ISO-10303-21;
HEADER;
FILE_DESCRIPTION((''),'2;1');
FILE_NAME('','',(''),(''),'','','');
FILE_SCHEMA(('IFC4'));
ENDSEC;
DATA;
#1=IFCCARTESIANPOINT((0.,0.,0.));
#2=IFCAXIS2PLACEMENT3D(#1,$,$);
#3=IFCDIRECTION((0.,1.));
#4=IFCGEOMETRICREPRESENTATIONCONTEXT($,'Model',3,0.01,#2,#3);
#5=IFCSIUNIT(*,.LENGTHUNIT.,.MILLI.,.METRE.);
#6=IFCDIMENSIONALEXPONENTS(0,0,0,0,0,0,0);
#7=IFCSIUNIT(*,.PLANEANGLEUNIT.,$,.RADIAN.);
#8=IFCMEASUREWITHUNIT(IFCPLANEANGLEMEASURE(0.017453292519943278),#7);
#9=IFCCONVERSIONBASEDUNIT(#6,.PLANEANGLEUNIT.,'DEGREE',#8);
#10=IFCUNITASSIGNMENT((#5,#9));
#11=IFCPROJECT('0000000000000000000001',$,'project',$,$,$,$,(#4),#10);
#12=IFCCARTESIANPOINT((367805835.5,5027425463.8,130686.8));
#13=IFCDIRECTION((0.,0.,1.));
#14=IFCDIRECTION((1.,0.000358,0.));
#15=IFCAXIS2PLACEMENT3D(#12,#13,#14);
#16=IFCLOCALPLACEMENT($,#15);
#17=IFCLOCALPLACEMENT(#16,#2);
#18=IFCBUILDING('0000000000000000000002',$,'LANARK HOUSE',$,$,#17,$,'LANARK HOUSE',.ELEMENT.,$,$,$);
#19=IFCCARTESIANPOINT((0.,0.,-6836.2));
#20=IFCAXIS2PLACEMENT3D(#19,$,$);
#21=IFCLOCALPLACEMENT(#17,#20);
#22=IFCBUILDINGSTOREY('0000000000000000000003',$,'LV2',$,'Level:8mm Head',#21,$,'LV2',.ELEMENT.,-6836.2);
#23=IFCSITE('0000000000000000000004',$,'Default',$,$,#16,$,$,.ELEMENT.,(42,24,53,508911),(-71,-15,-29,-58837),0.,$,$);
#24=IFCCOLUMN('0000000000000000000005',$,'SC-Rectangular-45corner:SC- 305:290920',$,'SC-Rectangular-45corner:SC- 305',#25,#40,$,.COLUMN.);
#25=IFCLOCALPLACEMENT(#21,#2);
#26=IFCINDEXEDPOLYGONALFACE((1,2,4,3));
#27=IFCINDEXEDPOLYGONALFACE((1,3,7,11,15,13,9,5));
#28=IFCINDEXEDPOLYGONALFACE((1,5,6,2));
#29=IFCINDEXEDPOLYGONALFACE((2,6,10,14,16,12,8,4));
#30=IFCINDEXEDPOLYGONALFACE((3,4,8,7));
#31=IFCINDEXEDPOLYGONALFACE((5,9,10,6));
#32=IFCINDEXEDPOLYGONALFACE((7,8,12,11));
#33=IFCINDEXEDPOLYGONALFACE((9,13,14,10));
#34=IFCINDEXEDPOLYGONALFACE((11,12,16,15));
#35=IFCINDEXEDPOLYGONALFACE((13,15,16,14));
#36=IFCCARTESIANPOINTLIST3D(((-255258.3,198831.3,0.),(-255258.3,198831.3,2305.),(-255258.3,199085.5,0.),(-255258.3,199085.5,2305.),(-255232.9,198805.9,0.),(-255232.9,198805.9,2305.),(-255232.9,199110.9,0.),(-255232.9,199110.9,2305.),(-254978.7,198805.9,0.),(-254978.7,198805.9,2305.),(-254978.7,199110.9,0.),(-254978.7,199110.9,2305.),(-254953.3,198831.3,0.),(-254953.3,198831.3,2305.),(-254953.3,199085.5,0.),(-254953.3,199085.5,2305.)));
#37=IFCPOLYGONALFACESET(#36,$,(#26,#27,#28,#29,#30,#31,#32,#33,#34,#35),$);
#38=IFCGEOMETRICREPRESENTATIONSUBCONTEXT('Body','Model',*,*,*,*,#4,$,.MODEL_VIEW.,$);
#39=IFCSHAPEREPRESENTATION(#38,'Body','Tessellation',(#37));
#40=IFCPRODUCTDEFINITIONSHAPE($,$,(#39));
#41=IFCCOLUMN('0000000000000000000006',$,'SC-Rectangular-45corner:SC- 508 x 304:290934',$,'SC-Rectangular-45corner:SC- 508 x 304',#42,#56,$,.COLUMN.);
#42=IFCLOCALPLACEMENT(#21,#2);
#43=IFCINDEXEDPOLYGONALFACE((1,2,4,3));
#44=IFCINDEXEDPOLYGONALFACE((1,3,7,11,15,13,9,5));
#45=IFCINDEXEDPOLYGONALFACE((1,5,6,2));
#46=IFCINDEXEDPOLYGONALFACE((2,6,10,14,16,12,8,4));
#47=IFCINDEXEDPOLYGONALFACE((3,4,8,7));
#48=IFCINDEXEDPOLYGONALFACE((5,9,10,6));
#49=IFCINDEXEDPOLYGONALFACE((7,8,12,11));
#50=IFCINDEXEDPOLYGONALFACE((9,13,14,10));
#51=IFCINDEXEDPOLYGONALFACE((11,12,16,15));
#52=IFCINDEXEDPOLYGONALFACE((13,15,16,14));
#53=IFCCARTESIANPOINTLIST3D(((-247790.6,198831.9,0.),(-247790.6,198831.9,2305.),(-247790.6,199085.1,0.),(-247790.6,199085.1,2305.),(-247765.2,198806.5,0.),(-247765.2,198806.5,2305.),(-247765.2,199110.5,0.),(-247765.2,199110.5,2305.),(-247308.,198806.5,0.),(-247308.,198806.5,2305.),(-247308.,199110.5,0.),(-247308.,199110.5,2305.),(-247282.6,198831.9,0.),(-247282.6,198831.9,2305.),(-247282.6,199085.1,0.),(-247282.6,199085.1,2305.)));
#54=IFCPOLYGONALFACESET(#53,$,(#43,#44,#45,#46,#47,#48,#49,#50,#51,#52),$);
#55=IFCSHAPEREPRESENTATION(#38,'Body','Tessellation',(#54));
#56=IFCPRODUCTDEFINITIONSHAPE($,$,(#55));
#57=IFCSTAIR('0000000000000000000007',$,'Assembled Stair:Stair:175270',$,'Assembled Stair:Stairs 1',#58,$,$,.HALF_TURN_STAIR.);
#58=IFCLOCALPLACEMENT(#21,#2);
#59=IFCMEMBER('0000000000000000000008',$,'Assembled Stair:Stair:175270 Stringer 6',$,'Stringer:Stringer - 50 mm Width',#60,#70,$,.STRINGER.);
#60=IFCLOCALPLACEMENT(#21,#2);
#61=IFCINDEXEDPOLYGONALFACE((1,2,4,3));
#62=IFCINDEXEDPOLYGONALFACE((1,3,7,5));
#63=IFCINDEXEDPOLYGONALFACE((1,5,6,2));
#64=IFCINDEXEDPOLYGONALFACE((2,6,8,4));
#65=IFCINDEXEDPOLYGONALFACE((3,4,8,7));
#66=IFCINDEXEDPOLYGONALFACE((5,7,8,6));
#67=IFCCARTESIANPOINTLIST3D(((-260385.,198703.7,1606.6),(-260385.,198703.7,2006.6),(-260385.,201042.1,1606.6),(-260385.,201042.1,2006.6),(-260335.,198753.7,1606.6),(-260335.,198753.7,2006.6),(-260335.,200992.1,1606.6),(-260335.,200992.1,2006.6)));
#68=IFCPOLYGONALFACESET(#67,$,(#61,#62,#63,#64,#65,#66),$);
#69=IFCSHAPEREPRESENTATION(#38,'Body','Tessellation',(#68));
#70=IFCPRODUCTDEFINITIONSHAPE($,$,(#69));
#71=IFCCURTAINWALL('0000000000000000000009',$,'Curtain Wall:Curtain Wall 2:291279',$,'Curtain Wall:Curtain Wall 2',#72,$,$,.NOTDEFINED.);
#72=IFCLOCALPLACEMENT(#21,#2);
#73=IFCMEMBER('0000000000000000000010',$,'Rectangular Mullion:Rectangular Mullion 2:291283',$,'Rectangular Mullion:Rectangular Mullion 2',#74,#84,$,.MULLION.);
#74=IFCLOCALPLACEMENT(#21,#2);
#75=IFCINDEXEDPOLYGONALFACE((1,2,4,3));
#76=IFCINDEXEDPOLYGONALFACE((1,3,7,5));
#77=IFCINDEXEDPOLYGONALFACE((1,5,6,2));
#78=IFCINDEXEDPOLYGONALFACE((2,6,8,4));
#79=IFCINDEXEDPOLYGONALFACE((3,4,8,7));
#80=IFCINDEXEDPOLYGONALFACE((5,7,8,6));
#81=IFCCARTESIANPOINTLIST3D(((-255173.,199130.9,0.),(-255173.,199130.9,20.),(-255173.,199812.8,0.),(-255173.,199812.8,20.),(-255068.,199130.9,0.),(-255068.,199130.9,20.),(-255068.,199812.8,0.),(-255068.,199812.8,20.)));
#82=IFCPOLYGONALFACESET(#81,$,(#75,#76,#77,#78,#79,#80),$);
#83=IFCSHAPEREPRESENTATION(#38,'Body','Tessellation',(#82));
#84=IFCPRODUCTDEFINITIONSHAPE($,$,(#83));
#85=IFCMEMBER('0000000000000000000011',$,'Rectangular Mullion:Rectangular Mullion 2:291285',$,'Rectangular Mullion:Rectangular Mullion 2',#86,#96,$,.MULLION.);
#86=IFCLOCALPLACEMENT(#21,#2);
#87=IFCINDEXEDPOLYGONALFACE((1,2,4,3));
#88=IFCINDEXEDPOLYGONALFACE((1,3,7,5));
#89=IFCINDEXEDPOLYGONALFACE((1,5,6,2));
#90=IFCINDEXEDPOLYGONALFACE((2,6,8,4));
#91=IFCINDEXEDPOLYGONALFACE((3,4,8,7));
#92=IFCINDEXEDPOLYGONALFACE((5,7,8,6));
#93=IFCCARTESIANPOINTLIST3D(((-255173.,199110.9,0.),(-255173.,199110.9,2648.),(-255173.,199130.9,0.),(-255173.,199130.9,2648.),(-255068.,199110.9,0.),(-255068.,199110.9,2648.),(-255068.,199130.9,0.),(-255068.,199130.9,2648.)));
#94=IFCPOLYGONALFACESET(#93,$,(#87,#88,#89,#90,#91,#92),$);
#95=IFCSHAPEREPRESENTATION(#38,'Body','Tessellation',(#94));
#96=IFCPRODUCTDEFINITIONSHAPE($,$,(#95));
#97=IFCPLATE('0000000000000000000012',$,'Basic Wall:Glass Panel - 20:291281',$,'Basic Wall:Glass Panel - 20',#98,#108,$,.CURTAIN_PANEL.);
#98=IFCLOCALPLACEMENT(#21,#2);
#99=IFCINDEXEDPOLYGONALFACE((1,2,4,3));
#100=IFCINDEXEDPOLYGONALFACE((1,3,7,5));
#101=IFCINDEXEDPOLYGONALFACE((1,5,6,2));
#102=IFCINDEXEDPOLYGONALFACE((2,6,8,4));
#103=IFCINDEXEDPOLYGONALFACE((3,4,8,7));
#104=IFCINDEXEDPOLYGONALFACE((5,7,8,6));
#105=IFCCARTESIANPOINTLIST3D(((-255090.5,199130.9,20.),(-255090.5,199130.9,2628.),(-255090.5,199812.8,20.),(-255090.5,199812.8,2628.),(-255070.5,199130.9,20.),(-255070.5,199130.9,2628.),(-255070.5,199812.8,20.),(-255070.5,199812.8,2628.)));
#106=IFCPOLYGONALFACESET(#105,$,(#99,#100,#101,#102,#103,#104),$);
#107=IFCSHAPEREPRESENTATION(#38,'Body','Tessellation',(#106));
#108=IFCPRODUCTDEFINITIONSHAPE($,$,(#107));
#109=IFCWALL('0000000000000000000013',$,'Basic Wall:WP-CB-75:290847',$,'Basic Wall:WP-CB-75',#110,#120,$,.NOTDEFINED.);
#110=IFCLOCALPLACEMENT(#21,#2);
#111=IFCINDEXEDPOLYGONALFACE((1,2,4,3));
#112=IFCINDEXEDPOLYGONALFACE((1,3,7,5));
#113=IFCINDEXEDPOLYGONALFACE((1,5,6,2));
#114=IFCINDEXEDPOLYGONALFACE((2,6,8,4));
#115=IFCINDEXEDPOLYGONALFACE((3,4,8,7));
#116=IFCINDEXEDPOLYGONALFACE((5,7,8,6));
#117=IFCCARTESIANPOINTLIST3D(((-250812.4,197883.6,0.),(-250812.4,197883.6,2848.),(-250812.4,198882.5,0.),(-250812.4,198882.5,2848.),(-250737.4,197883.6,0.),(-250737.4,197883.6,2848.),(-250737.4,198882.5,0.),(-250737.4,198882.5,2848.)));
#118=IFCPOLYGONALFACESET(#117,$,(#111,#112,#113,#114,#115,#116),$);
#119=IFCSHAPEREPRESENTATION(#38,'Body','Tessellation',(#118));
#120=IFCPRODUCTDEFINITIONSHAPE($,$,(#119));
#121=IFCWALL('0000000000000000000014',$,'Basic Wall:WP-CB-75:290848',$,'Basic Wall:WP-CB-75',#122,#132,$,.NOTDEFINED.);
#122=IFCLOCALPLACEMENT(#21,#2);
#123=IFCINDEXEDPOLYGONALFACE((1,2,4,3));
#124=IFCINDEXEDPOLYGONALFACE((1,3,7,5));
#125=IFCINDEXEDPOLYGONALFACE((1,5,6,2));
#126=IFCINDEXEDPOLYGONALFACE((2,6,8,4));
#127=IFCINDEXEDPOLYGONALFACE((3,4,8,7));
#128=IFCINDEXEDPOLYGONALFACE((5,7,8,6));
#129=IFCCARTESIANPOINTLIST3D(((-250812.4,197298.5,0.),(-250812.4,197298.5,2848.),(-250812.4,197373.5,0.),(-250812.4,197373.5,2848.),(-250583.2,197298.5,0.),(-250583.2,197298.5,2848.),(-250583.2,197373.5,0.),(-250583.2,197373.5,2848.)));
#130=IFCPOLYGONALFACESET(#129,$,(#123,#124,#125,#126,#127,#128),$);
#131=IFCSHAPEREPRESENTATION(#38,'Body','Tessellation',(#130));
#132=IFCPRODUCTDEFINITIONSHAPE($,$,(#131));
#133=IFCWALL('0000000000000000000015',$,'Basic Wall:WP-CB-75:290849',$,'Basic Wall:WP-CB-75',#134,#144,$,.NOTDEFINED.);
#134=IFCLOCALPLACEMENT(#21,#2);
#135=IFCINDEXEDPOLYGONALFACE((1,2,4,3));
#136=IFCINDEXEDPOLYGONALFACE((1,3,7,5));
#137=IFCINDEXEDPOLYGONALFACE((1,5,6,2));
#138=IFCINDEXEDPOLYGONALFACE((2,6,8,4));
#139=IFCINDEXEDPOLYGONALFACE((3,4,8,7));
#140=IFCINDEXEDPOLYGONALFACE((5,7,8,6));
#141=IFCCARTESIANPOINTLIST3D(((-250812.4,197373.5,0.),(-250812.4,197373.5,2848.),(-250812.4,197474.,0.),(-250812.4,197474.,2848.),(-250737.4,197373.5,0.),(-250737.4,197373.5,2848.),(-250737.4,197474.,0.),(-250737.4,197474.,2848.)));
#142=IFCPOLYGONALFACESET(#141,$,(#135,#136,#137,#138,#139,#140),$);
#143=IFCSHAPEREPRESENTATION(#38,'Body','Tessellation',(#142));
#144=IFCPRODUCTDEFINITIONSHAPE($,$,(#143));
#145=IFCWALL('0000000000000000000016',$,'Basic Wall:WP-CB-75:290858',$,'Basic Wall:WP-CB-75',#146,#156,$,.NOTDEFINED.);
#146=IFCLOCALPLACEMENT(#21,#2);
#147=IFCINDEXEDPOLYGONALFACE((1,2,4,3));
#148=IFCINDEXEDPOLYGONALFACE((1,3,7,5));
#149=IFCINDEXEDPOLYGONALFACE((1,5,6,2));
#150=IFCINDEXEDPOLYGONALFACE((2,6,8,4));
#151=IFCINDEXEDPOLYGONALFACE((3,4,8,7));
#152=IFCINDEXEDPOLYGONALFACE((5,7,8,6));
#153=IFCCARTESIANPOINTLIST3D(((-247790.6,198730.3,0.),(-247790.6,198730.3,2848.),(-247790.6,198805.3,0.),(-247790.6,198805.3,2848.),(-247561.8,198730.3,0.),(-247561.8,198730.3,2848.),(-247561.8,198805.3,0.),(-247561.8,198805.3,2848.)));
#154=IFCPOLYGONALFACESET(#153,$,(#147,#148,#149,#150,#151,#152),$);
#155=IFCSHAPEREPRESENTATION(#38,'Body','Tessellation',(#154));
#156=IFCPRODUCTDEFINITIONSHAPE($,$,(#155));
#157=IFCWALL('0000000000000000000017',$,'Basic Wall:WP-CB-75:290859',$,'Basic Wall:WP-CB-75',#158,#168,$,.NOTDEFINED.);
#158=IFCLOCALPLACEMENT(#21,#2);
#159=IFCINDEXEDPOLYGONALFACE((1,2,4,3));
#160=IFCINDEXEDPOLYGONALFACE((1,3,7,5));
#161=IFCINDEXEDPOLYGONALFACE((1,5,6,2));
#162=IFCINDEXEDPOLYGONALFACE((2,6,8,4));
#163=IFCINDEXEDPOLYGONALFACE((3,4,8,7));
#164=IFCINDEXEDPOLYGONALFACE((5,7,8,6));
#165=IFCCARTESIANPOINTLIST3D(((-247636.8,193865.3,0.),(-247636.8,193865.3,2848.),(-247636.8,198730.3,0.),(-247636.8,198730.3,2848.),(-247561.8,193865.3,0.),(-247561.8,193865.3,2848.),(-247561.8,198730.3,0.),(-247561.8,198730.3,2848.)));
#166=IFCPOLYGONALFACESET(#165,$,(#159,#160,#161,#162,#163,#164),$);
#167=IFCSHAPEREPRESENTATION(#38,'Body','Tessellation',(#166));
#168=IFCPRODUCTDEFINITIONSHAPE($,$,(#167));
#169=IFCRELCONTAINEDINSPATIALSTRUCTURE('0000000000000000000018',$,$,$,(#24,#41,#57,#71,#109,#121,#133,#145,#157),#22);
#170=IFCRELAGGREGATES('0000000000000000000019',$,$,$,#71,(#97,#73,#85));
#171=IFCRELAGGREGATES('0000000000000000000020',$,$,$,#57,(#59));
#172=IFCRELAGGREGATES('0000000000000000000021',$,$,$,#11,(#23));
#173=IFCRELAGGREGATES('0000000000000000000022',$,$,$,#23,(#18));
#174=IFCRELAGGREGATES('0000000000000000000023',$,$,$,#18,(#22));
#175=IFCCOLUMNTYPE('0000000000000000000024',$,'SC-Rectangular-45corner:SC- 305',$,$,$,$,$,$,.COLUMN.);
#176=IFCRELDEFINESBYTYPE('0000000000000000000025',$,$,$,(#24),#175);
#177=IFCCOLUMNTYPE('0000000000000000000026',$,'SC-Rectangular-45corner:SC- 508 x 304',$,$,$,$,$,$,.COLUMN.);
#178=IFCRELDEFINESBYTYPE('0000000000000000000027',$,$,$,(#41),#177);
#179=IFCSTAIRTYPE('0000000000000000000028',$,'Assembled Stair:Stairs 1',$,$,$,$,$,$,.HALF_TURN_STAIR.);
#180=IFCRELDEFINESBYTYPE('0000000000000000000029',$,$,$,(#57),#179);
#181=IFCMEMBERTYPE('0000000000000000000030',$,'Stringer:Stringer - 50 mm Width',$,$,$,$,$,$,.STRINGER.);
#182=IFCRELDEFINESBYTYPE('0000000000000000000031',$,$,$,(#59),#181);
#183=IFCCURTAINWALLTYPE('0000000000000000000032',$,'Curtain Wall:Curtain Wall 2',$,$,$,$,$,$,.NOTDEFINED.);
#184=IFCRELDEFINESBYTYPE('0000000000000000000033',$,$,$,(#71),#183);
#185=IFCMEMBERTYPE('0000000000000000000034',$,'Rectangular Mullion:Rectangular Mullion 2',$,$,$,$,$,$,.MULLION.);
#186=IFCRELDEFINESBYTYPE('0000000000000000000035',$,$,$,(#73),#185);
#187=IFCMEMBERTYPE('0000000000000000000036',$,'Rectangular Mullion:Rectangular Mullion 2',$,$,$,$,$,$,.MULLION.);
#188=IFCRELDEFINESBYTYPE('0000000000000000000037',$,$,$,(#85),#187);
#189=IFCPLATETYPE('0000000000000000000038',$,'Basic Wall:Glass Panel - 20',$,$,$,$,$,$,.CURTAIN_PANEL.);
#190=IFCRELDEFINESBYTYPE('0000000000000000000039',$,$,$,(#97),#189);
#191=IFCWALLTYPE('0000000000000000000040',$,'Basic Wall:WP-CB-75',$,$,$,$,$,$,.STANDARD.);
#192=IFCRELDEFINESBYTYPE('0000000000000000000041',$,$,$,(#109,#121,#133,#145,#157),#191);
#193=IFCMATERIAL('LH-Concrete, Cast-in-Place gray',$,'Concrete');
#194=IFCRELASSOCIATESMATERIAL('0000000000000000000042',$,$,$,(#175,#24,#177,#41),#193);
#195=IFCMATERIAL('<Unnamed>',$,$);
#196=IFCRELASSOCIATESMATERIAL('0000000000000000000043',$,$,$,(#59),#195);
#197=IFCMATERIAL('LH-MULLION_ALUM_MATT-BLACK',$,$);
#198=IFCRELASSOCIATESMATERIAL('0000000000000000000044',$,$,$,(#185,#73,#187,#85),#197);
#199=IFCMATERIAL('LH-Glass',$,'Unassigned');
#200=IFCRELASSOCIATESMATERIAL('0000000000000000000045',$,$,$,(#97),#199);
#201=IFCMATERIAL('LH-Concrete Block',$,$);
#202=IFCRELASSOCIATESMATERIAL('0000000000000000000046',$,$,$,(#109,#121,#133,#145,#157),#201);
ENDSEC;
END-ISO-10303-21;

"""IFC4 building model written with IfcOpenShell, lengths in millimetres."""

from ifc_helpers import new_model, entity, si_unit, converted_unit, direction, frame, origin, place, context, subcontext, project, spatial, indexed_curve, outline, extrude, source, transform, mapped, material, type_object, type_shapes, element, aggregate, save


model = new_model("IFC4")

# Units and contexts
model_context = context("Model", 3, precision=0.01, world=origin(), true_north=direction((0.0, 1.0)))
body_context = subcontext(model_context, "Body", "Model", "MODEL_VIEW")
ifc_project = project(units=[si_unit("LENGTHUNIT", "METRE", prefix="MILLI"), converted_unit("PLANEANGLEUNIT", "DEGREE", entity("IfcPlaneAngleMeasure", 0.017453292519943278), si_unit("PLANEANGLEUNIT", "RADIAN"), dimensions=[0, 0, 0, 0, 0, 0, 0])], contexts=[model_context])

# Site, building, storey
site_placement = place(None, frame((367805835.5, 5027425463.8, 130686.8), z_axis=(0.0, 0.0, 1.0), x_axis=(1.0, 0.000358, 0.0)))
site = spatial("IfcSite", under=ifc_project, at=site_placement, Name="Default", CompositionType="ELEMENT", RefLatitude=(42, 24, 53, 508911), RefLongitude=(-71, -15, -29, -58837), RefElevation=0.0)
building_placement = place(site_placement, origin())
building = spatial("IfcBuilding", under=site, at=building_placement, Name="LANARK HOUSE", LongName="LANARK HOUSE", CompositionType="ELEMENT")
storey_placement = place(building_placement, frame((0.0, 0.0, -6836.2)))
storey = spatial("IfcBuildingStorey", under=building, at=storey_placement, Name="LV2", ObjectType="Level:8mm Head", LongName="LV2", CompositionType="ELEMENT", Elevation=-6836.2)

# Columns
ifc_material_1 = material(Name="LH-Concrete, Cast-in-Place gray", Category="Concrete")
column_type_1 = type_object("IfcColumnType", Name="SC-Rectangular-45corner:SC- 305", PredefinedType="COLUMN", material=ifc_material_1)
shared_shape_1 = source(origin(), body_context, "Body", "SweptSolid", [
    extrude(outline(indexed_curve([(-127.1, -152.5), (127.1, -152.5), (152.5, -127.1), (152.5, 127.1), (127.1, 152.5), (-127.1, 152.5), (-152.5, 127.1), (-152.5, -127.1), (-127.1, -152.5)], self_intersect=False)), frame((0.0, 0.0, -6836.2), z_axis=(0.0, 0.0, 1.0), x_axis=(-1.0, 0.0, 0.0)), (0.0, 0.0, 1.0), 2305.0),
])
type_shapes(column_type_1, [shared_shape_1])
column_1_placement = place(storey_placement, frame((-255105.8, 198958.4, 6836.2)))
element("IfcColumn", 1, at=column_1_placement, inside=storey, type_object=column_type_1, material=ifc_material_1, Name="SC-Rectangular-45corner:SC- 305:290920", ObjectType="SC-Rectangular-45corner:SC- 305", PredefinedType="COLUMN", context=body_context, shape_type="MappedRepresentation", body=[
    mapped(shared_shape_1, transform((0.0, 0.0, 0.0), scale=1.0)),
])
column_type_2 = type_object("IfcColumnType", Name="SC-Rectangular-45corner:SC- 508 x 304", PredefinedType="COLUMN", material=ifc_material_1)
shared_shape_2 = source(origin(), body_context, "Body", "SweptSolid", [
    extrude(outline(indexed_curve([(-228.6, -152.0), (228.6, -152.0), (254.0, -126.6), (254.0, 126.6), (228.6, 152.0), (-228.6, 152.0), (-254.0, 126.6), (-254.0, -126.6), (-228.6, -152.0)], self_intersect=False)), frame((0.0, 0.0, -6836.2), z_axis=(0.0, 0.0, 1.0), x_axis=(-1.0, 0.0, 0.0)), (0.0, 0.0, 1.0), 2305.0),
])
type_shapes(column_type_2, [shared_shape_2])
column_2_placement = place(storey_placement, frame((-247536.6, 198958.5, 6836.2)))
element("IfcColumn", 2, at=column_2_placement, inside=storey, type_object=column_type_2, material=ifc_material_1, Name="SC-Rectangular-45corner:SC- 508 x 304:290934", ObjectType="SC-Rectangular-45corner:SC- 508 x 304", PredefinedType="COLUMN", context=body_context, shape_type="MappedRepresentation", body=[
    mapped(shared_shape_2, transform((0.0, 0.0, 0.0), scale=1.0)),
])

# Stair, member
stair_type = type_object("IfcStairType", Name="Assembled Stair:Stairs 1", PredefinedType="HALF_TURN_STAIR")
stair_placement = place(storey_placement, origin())
stair = element("IfcStair", 3, at=stair_placement, inside=storey, type_object=stair_type, Name="Assembled Stair:Stair:175270", ObjectType="Assembled Stair:Stairs 1", PredefinedType="HALF_TURN_STAIR")
ifc_material_2 = material(Name="<Unnamed>")
member_type_1 = type_object("IfcMemberType", Name="Stringer:Stringer - 50 mm Width", PredefinedType="STRINGER")
member_1_placement = place(stair_placement, frame((-260385.0, 198703.7, 1606.6)))
member_1 = element("IfcMember", 4, at=member_1_placement, type_object=member_type_1, material=ifc_material_2, Name="Assembled Stair:Stair:175270 Stringer 6", ObjectType="Stringer:Stringer - 50 mm Width", PredefinedType="STRINGER", context=body_context, shape_type="SweptSolid", body=[
    extrude(outline(indexed_curve([(-1169.2, -25.0), (1169.2, -25.0), (1119.2, 25.0), (-1119.2, 25.0), (-1169.2, -25.0)], self_intersect=False)), frame((25.0, 1169.2, 0.0), z_axis=(0.0, 0.0, 1.0), x_axis=(0.0, -1.0, 0.0)), (0.0, 0.0, 1.0), 400.0),
])

# Curtain wall, members
curtain_wall_type = type_object("IfcCurtainWallType", Name="Curtain Wall:Curtain Wall 2", PredefinedType="NOTDEFINED")
curtain_wall_placement = place(storey_placement, frame((0.0, 0.0, 6836.2)))
curtain_wall = element("IfcCurtainWall", 5, at=curtain_wall_placement, inside=storey, type_object=curtain_wall_type, Name="Curtain Wall:Curtain Wall 2:291279", ObjectType="Curtain Wall:Curtain Wall 2", PredefinedType="NOTDEFINED")
ifc_material_3 = material(Name="LH-MULLION_ALUM_MATT-BLACK")
member_type_2 = type_object("IfcMemberType", Name="Rectangular Mullion:Rectangular Mullion 2", PredefinedType="MULLION", material=ifc_material_3)
shared_shape_3 = source(origin(), body_context, "Body", "SweptSolid", [
    extrude(outline(indexed_curve([(-10.0, -52.5), (10.0, -52.5), (10.0, 52.5), (-10.0, 52.5), (-10.0, -52.5)], self_intersect=False)), frame((-10.0, -40.0, -681.9), z_axis=(0.0, 0.0, 1.0), x_axis=(-1.0, 0.0, 0.0)), (0.0, 0.0, 1.0), 681.9),
])
type_shapes(member_type_2, [shared_shape_3])
member_2_placement = place(curtain_wall_placement, frame((-255080.5, 199130.9, -6836.2), z_axis=(0.0, -1.0, 0.0), x_axis=(0.0, 0.0, -1.0)))
member_2 = element("IfcMember", 6, at=member_2_placement, type_object=member_type_2, material=ifc_material_3, Name="Rectangular Mullion:Rectangular Mullion 2:291283", ObjectType="Rectangular Mullion:Rectangular Mullion 2", PredefinedType="MULLION", context=body_context, shape_type="MappedRepresentation", body=[
    mapped(shared_shape_3, transform((0.0, 0.0, 0.0), scale=1.0)),
])
member_type_3 = type_object("IfcMemberType", Name="Rectangular Mullion:Rectangular Mullion 2", PredefinedType="MULLION", material=ifc_material_3)
shared_shape_4 = source(origin(), body_context, "Body", "SweptSolid", [
    extrude(outline(indexed_curve([(-10.0, -52.5), (10.0, -52.5), (10.0, 52.5), (-10.0, 52.5), (-10.0, -52.5)], self_intersect=False)), frame((-10.0, -40.0, -2648.0), z_axis=(0.0, 0.0, 1.0), x_axis=(-1.0, 0.0, 0.0)), (0.0, 0.0, 1.0), 2648.0),
])
type_shapes(member_type_3, [shared_shape_4])
member_3_placement = place(curtain_wall_placement, frame((-255080.5, 199110.9, -4188.2), z_axis=(0.0, 0.0, 1.0), x_axis=(0.0, -1.0, 0.0)))
member_3 = element("IfcMember", 7, at=member_3_placement, type_object=member_type_3, material=ifc_material_3, Name="Rectangular Mullion:Rectangular Mullion 2:291285", ObjectType="Rectangular Mullion:Rectangular Mullion 2", PredefinedType="MULLION", context=body_context, shape_type="MappedRepresentation", body=[
    mapped(shared_shape_4, transform((0.0, 0.0, 0.0), scale=1.0)),
])

# Plate
ifc_material_4 = material(Name="LH-Glass", Category="Unassigned")
plate_type = type_object("IfcPlateType", Name="Basic Wall:Glass Panel - 20", PredefinedType="CURTAIN_PANEL")
plate_placement = place(storey_placement, frame((-255080.5, 199130.9, 20.0), z_axis=(0.0, 0.0, 1.0), x_axis=(0.0, 1.0, 0.0)))
plate = element("IfcPlate", 8, at=plate_placement, type_object=plate_type, material=ifc_material_4, Name="Basic Wall:Glass Panel - 20:291281", ObjectType="Basic Wall:Glass Panel - 20", PredefinedType="CURTAIN_PANEL", context=body_context, shape_type="SweptSolid", body=[
    extrude(outline(indexed_curve([(-10.0, -341.0), (10.0, -341.0), (10.0, 341.0), (-10.0, 341.0), (-10.0, -341.0)], self_intersect=False)), frame((341.0, 0.0, 0.0), z_axis=(0.0, 0.0, 1.0), x_axis=(0.0, 1.0, 0.0)), (0.0, 0.0, 1.0), 2608.0),
])
aggregate(curtain_wall, [plate, member_2, member_3])

# Walls
ifc_material_5 = material(Name="LH-Concrete Block")
wall_type_1 = type_object("IfcWallType", Name="Basic Wall:WP-CB-75", PredefinedType="STANDARD")
wall_1_placement = place(storey_placement, frame((-250774.9, 198882.5, 0.0), z_axis=(0.0, 0.0, 1.0), x_axis=(0.0, -1.0, 0.0)))
element("IfcWall", 9, at=wall_1_placement, inside=storey, type_object=wall_type_1, material=ifc_material_5, Name="Basic Wall:WP-CB-75:290847", ObjectType="Basic Wall:WP-CB-75", PredefinedType="NOTDEFINED", context=body_context, shape_type="SweptSolid", body=[
    extrude(outline(indexed_curve([(998.9, 37.5), (0.0, 37.5), (0.0, -37.5), (998.9, -37.5), (998.9, 37.5)], self_intersect=False)), origin(), (0.0, 0.0, 1.0), 2848.0),
])
wall_2_placement = place(storey_placement, frame((-250583.2, 197336.0, 0.0), z_axis=(0.0, 0.0, 1.0), x_axis=(-1.0, 0.0, 0.0)))
element("IfcWall", 10, at=wall_2_placement, inside=storey, type_object=wall_type_1, material=ifc_material_5, Name="Basic Wall:WP-CB-75:290848", ObjectType="Basic Wall:WP-CB-75", PredefinedType="NOTDEFINED", context=body_context, shape_type="SweptSolid", body=[
    extrude(outline(indexed_curve([(229.2, 37.5), (0.0, 37.5), (0.0, -37.5), (229.2, -37.5), (229.2, 37.5)], self_intersect=False)), origin(), (0.0, 0.0, 1.0), 2848.0),
])
wall_3_placement = place(storey_placement, frame((-250774.9, 197373.5, 0.0), z_axis=(0.0, 0.0, 1.0), x_axis=(0.0, 1.0, 0.0)))
element("IfcWall", 11, at=wall_3_placement, inside=storey, type_object=wall_type_1, material=ifc_material_5, Name="Basic Wall:WP-CB-75:290849", ObjectType="Basic Wall:WP-CB-75", PredefinedType="NOTDEFINED", context=body_context, shape_type="SweptSolid", body=[
    extrude(outline(indexed_curve([(100.5, 37.5), (0.0, 37.5), (0.0, -37.5), (100.5, -37.5), (100.5, 37.5)], self_intersect=False)), origin(), (0.0, 0.0, 1.0), 2848.0),
])
wall_4_placement = place(storey_placement, frame((-247790.6, 198767.8, 0.0)))
element("IfcWall", 12, at=wall_4_placement, inside=storey, type_object=wall_type_1, material=ifc_material_5, Name="Basic Wall:WP-CB-75:290858", ObjectType="Basic Wall:WP-CB-75", PredefinedType="NOTDEFINED", context=body_context, shape_type="SweptSolid", body=[
    extrude(outline(indexed_curve([(228.8, 37.5), (0.0, 37.5), (0.0, -37.5), (228.8, -37.5), (228.8, 37.5)], self_intersect=False)), origin(), (0.0, 0.0, 1.0), 2848.0),
])
wall_5_placement = place(storey_placement, frame((-247599.3, 193865.3, 0.0), z_axis=(0.0, 0.0, 1.0), x_axis=(0.0, 1.0, 0.0)))
element("IfcWall", 13, at=wall_5_placement, inside=storey, type_object=wall_type_1, material=ifc_material_5, Name="Basic Wall:WP-CB-75:290859", ObjectType="Basic Wall:WP-CB-75", PredefinedType="NOTDEFINED", context=body_context, shape_type="SweptSolid", body=[
    extrude(outline(indexed_curve([(4864.9, 37.5), (0.0, 37.5), (0.0, -37.5), (4864.9, -37.5), (4864.9, 37.5)], self_intersect=False)), origin(), (0.0, 0.0, 1.0), 2848.0),
])

aggregate(stair, [member_1])

save(model, "model.ifc")
